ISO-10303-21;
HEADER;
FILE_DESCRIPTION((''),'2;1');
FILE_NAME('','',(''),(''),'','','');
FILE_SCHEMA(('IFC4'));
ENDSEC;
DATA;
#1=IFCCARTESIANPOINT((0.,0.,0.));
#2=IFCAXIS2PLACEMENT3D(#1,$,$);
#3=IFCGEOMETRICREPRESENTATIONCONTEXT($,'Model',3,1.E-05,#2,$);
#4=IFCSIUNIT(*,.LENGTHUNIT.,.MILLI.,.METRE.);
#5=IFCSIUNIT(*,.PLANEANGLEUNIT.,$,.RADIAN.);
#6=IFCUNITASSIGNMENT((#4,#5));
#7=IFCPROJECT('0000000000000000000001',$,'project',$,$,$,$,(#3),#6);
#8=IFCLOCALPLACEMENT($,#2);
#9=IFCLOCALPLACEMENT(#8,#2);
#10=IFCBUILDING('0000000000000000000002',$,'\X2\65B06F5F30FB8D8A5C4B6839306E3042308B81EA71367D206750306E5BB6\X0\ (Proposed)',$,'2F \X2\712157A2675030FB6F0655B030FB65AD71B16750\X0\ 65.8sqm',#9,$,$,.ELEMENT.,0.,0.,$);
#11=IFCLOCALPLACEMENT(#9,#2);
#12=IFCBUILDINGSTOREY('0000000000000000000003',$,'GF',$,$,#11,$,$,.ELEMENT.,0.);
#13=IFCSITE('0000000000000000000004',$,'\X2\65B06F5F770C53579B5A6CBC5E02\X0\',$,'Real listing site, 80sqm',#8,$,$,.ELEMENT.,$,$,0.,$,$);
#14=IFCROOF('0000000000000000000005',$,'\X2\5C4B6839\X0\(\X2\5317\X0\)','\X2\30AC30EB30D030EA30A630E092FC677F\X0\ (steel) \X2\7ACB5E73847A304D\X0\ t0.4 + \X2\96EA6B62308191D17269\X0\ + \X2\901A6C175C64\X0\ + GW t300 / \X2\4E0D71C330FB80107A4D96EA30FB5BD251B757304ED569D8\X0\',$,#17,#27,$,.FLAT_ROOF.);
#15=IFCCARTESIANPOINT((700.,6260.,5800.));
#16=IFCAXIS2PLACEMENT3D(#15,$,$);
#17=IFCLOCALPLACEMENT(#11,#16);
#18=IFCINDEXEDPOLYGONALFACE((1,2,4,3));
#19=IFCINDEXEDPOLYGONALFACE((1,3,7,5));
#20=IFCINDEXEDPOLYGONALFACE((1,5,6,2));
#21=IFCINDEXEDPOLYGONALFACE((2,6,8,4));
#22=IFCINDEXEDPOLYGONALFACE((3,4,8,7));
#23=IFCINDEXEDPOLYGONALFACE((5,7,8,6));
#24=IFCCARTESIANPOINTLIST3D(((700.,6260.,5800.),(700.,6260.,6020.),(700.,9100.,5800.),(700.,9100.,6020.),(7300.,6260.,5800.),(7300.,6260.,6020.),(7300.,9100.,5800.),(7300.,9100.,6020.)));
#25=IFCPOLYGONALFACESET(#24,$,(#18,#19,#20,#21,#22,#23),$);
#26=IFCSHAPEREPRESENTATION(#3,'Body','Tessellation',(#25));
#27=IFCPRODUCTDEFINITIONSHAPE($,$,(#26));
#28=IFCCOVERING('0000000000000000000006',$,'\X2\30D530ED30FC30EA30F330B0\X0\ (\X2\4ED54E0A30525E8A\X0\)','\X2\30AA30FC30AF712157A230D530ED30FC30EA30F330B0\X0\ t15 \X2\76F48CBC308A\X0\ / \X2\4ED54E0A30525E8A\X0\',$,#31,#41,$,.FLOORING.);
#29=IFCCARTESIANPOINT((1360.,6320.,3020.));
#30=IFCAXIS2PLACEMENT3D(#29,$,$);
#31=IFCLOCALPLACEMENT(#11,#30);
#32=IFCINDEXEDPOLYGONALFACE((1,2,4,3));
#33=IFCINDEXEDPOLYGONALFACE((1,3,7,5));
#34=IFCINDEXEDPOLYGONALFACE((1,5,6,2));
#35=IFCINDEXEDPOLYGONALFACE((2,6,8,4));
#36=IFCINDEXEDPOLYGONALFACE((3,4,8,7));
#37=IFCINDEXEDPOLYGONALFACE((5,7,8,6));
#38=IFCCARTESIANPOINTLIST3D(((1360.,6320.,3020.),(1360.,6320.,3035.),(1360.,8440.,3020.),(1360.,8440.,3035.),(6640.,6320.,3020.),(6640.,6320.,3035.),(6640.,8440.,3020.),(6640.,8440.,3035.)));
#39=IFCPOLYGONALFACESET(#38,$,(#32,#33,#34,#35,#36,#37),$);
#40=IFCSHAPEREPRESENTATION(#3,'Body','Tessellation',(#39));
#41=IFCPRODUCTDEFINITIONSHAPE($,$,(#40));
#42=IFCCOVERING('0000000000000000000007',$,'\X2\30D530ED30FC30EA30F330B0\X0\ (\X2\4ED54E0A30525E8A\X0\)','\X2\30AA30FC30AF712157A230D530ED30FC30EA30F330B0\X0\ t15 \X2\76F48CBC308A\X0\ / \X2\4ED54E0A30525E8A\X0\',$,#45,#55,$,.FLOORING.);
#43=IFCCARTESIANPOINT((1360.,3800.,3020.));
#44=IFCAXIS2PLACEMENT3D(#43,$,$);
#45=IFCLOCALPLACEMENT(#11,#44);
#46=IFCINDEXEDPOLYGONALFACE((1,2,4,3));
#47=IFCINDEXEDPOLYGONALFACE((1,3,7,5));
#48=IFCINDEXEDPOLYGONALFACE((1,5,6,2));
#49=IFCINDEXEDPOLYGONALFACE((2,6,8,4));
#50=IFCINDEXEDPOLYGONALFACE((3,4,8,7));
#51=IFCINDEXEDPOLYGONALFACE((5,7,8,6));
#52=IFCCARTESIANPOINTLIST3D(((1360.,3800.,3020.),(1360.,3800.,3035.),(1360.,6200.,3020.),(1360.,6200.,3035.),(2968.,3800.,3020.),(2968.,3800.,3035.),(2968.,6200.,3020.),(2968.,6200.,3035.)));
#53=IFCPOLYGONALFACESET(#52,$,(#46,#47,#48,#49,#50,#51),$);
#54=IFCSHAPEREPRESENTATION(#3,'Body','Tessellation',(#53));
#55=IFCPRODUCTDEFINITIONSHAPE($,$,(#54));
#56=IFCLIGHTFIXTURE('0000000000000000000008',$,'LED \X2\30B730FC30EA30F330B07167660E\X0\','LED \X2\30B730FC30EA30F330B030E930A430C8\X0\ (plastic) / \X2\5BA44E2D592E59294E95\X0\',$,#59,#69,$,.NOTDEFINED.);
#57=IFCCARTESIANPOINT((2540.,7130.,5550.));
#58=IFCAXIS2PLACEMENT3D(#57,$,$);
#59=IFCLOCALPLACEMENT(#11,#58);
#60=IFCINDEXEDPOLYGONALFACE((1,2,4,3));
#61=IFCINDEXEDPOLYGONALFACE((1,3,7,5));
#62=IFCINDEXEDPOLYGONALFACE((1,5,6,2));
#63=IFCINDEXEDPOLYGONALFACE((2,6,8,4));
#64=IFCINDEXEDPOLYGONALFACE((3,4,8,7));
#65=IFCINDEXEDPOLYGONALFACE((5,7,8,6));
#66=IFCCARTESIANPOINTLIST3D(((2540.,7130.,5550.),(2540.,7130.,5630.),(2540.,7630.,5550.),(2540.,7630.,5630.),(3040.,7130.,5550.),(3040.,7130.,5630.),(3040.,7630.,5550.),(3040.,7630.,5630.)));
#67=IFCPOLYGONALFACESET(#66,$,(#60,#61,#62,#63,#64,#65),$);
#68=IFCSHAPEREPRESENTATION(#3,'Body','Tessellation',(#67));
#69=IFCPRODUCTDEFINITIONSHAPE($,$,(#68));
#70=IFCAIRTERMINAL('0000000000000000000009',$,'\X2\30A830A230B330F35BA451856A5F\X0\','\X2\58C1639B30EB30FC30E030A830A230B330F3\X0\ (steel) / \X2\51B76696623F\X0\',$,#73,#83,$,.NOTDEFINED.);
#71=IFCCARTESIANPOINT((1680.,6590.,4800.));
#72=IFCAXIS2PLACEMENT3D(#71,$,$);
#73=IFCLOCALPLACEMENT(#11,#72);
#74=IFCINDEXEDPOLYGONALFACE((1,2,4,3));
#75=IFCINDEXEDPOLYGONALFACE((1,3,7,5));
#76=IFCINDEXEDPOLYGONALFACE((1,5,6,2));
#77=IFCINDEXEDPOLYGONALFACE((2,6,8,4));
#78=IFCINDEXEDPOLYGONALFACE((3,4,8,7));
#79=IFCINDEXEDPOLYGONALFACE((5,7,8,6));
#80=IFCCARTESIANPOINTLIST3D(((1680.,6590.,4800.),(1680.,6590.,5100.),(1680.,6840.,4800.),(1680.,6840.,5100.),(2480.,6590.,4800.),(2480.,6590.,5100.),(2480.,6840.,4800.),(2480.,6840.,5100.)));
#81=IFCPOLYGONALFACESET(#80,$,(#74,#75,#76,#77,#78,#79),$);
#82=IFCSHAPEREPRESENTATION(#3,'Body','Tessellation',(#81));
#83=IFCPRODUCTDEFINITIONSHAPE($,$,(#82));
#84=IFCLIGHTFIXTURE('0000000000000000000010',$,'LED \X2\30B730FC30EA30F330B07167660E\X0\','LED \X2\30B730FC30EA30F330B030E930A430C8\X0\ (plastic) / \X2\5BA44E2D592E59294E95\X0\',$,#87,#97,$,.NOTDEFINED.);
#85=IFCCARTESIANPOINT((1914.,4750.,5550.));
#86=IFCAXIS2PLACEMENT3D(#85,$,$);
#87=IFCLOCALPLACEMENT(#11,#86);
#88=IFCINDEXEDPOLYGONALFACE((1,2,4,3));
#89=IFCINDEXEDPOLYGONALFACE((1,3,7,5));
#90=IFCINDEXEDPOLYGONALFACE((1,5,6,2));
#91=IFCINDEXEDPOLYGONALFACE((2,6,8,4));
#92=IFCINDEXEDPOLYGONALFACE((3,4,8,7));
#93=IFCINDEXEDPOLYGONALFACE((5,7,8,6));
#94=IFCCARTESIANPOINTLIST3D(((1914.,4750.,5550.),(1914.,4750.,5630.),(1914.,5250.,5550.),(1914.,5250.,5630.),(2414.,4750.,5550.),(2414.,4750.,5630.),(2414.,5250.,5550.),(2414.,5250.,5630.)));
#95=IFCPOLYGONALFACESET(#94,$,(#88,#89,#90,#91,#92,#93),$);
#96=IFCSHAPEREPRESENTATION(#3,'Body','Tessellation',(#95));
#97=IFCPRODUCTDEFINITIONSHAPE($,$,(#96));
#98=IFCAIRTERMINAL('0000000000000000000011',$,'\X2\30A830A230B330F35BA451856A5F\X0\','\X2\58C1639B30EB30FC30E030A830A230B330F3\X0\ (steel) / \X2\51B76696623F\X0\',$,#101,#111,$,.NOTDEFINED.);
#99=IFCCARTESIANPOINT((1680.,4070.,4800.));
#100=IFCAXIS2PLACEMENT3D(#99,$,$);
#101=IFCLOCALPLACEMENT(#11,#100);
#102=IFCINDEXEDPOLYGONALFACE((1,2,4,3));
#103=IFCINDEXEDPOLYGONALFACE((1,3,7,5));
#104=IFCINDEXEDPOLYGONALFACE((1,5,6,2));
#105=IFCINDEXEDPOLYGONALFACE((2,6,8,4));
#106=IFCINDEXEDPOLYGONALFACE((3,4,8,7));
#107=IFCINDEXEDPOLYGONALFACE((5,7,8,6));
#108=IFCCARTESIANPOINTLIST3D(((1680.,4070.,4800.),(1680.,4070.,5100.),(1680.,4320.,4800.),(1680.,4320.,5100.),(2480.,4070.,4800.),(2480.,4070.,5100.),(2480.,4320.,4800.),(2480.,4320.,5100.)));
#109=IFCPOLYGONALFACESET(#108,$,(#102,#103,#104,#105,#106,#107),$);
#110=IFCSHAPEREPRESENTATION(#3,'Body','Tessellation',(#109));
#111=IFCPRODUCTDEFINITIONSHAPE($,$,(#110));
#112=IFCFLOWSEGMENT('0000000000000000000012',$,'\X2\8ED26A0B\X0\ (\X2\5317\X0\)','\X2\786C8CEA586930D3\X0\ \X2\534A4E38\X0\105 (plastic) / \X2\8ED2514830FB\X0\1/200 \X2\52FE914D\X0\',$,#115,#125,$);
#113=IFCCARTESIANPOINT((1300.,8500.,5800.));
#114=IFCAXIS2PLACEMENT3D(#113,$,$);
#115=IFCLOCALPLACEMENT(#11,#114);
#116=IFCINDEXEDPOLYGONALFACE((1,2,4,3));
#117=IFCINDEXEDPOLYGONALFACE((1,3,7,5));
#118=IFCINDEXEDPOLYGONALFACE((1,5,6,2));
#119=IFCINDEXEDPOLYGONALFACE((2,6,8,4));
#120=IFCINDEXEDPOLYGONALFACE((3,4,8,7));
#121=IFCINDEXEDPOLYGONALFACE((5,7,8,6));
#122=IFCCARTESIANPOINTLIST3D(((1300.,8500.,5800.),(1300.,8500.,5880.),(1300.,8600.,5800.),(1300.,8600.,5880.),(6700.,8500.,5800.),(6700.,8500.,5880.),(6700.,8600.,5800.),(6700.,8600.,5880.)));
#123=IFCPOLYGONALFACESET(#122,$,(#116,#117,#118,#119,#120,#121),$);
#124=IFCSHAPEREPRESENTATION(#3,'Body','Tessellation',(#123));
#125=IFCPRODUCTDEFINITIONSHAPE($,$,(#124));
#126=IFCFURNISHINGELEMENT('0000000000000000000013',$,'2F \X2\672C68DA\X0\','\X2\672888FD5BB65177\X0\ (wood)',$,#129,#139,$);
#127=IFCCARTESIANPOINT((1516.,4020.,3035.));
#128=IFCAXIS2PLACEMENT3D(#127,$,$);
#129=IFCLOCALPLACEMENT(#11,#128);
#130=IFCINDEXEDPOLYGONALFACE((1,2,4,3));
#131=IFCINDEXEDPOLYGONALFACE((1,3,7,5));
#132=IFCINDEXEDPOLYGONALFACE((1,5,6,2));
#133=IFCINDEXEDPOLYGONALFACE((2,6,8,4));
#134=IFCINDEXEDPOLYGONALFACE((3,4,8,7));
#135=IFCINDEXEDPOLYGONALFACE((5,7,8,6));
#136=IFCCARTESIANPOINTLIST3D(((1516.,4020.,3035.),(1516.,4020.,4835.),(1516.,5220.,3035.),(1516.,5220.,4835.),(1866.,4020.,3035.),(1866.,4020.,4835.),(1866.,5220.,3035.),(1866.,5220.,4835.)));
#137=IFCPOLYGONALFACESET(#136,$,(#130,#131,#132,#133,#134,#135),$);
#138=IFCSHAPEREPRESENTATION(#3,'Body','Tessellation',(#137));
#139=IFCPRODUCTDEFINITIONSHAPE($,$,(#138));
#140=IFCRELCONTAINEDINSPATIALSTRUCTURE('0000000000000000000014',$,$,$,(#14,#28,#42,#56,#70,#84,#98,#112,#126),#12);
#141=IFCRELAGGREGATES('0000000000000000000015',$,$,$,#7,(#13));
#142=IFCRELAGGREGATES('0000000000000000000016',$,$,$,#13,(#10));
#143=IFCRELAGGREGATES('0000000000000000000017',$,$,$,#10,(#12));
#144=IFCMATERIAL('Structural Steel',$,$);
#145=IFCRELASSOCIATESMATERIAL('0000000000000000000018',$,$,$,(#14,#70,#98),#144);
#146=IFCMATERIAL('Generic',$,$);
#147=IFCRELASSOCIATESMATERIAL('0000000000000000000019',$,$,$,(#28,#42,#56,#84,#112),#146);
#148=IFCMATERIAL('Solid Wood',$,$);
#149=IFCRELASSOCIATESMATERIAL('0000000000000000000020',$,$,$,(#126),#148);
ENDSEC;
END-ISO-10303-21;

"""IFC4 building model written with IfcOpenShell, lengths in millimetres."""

from ifc_helpers import new_model, si_unit, frame, frame_2d, origin, place, context, project, spatial, rectangle, extrude, material, element, save


model = new_model("IFC4")

# Units and contexts
model_context = context("Model", 3, precision=1e-05, world=origin())
ifc_project = project(units=[si_unit("LENGTHUNIT", "METRE", prefix="MILLI"), si_unit("PLANEANGLEUNIT", "RADIAN")], contexts=[model_context])

# Site, building, storey
site_placement = place(None, origin())
site = spatial("IfcSite", under=ifc_project, at=site_placement, Name="新潟県南魚沼市", ObjectType="Real listing site, 80sqm", CompositionType="ELEMENT", RefElevation=0.0)
building_placement = place(site_placement, origin())
building = spatial("IfcBuilding", under=site, at=building_placement, Name="新潟・越屋根のある自然素材の家 (Proposed)", ObjectType="2F 無垢材・漆喰・断熱材 65.8sqm", CompositionType="ELEMENT", ElevationOfRefHeight=0.0, ElevationOfTerrain=0.0)
storey_placement = place(building_placement, origin())
storey = spatial("IfcBuildingStorey", under=building, at=storey_placement, Name="GF", CompositionType="ELEMENT", Elevation=0.0)

# Shared definitions
ifc_material_1 = material(Name="Solid Wood")

# Roof
ifc_material_2 = material(Name="Structural Steel")
for number, where, name in (
    (1, (700.0, 6260.0, 5800.0), "屋根(北)"),
):
    element("IfcRoof", number, at=place(storey_placement, frame(where)), inside=storey, material=ifc_material_2, Name=name, Description="ガルバリウム鋼板 (steel) 立平葺き t0.4 + 雪止め金物 + 通気層 + GW t300 / 不燃・耐積雪・寒冷地仕様", PredefinedType="FLAT_ROOF", context=model_context, shape_type="SweptSolid", body=[
        extrude(rectangle(XDim=6600.0, YDim=2840.0, at=frame_2d((3300.0, 1420.0))), frame((700.0, 6260.0, 5800.0)), (0.0, 0.0, 1.0), 220.0),
    ])

# Coverings
ifc_material_3 = material(Name="Generic")
covering_1_placement = place(storey_placement, frame((1360.0, 6320.0, 3020.0)))
element("IfcCovering", 2, at=covering_1_placement, inside=storey, material=ifc_material_3, Name="フローリング (仕上げ床)", Description="オーク無垢フローリング t15 直貼り / 仕上げ床", PredefinedType="FLOORING", context=model_context, shape_type="SweptSolid", body=[
    extrude(rectangle(XDim=5280.0, YDim=2120.0, at=frame_2d((2640.0, 1060.0))), frame((1360.0, 6320.0, 3020.0)), (0.0, 0.0, 1.0), 15.0),
])
covering_2_placement = place(storey_placement, frame((1360.0, 3800.0, 3020.0)))
element("IfcCovering", 3, at=covering_2_placement, inside=storey, material=ifc_material_3, Name="フローリング (仕上げ床)", Description="オーク無垢フローリング t15 直貼り / 仕上げ床", PredefinedType="FLOORING", context=model_context, shape_type="SweptSolid", body=[
    extrude(rectangle(XDim=1608.0, YDim=2400.0, at=frame_2d((804.0, 1200.0))), frame((1360.0, 3800.0, 3020.0)), (0.0, 0.0, 1.0), 15.0),
])

# Light fixture
light_fixture_1_placement = place(storey_placement, frame((2540.0, 7130.0, 5550.0)))
element("IfcLightFixture", 4, at=light_fixture_1_placement, inside=storey, material=ifc_material_3, Name="LED シーリング照明", Description="LED シーリングライト (plastic) / 室中央天井", PredefinedType="NOTDEFINED", context=model_context, shape_type="SweptSolid", body=[
    extrude(rectangle(XDim=500.0, YDim=500.0, at=frame_2d((250.0, 250.0))), frame((2540.0, 7130.0, 5550.0)), (0.0, 0.0, 1.0), 80.0),
])

# Air terminal
air_terminal_1_placement = place(storey_placement, frame((1680.0, 6590.0, 4800.0)))
element("IfcAirTerminal", 5, at=air_terminal_1_placement, inside=storey, material=ifc_material_2, Name="エアコン室内機", Description="壁掛ルームエアコン (steel) / 冷暖房", PredefinedType="NOTDEFINED", context=model_context, shape_type="SweptSolid", body=[
    extrude(rectangle(XDim=800.0, YDim=250.0, at=frame_2d((400.0, 125.0))), frame((1680.0, 6590.0, 4800.0)), (0.0, 0.0, 1.0), 300.0),
])

# Light fixture
light_fixture_2_placement = place(storey_placement, frame((1914.0, 4750.0, 5550.0)))
element("IfcLightFixture", 6, at=light_fixture_2_placement, inside=storey, material=ifc_material_3, Name="LED シーリング照明", Description="LED シーリングライト (plastic) / 室中央天井", PredefinedType="NOTDEFINED", context=model_context, shape_type="SweptSolid", body=[
    extrude(rectangle(XDim=500.0, YDim=500.0, at=frame_2d((250.0, 250.0))), frame((1914.0, 4750.0, 5550.0)), (0.0, 0.0, 1.0), 80.0),
])

# Air terminal
air_terminal_2_placement = place(storey_placement, frame((1680.0, 4070.0, 4800.0)))
element("IfcAirTerminal", 7, at=air_terminal_2_placement, inside=storey, material=ifc_material_2, Name="エアコン室内機", Description="壁掛ルームエアコン (steel) / 冷暖房", PredefinedType="NOTDEFINED", context=model_context, shape_type="SweptSolid", body=[
    extrude(rectangle(XDim=800.0, YDim=250.0, at=frame_2d((400.0, 125.0))), frame((1680.0, 4070.0, 4800.0)), (0.0, 0.0, 1.0), 300.0),
])

# Flow segment
flow_segment_placement = place(storey_placement, frame((1300.0, 8500.0, 5800.0)))
element("IfcFlowSegment", 8, at=flow_segment_placement, inside=storey, material=ifc_material_3, Name="軒樋 (北)", Description="硬質塩ビ 半丸105 (plastic) / 軒先・1/200 勾配", context=model_context, shape_type="SweptSolid", body=[
    extrude(rectangle(XDim=5400.0, YDim=100.0, at=frame_2d((2700.0, 50.0))), frame((1300.0, 8500.0, 5800.0)), (0.0, 0.0, 1.0), 80.0),
])

# Furnishing element
furnishing_placement = place(storey_placement, frame((1516.0, 4020.0, 3035.0)))
element("IfcFurnishingElement", 9, at=furnishing_placement, inside=storey, material=ifc_material_1, Name="2F 本棚", Description="木製家具 (wood)", context=model_context, shape_type="SweptSolid", body=[
    extrude(rectangle(XDim=350.0, YDim=1200.0, at=frame_2d((175.0, 600.0))), frame((1516.0, 4020.0, 3035.0)), (0.0, 0.0, 1.0), 1800.0),
])

save(model, "model.ifc")
